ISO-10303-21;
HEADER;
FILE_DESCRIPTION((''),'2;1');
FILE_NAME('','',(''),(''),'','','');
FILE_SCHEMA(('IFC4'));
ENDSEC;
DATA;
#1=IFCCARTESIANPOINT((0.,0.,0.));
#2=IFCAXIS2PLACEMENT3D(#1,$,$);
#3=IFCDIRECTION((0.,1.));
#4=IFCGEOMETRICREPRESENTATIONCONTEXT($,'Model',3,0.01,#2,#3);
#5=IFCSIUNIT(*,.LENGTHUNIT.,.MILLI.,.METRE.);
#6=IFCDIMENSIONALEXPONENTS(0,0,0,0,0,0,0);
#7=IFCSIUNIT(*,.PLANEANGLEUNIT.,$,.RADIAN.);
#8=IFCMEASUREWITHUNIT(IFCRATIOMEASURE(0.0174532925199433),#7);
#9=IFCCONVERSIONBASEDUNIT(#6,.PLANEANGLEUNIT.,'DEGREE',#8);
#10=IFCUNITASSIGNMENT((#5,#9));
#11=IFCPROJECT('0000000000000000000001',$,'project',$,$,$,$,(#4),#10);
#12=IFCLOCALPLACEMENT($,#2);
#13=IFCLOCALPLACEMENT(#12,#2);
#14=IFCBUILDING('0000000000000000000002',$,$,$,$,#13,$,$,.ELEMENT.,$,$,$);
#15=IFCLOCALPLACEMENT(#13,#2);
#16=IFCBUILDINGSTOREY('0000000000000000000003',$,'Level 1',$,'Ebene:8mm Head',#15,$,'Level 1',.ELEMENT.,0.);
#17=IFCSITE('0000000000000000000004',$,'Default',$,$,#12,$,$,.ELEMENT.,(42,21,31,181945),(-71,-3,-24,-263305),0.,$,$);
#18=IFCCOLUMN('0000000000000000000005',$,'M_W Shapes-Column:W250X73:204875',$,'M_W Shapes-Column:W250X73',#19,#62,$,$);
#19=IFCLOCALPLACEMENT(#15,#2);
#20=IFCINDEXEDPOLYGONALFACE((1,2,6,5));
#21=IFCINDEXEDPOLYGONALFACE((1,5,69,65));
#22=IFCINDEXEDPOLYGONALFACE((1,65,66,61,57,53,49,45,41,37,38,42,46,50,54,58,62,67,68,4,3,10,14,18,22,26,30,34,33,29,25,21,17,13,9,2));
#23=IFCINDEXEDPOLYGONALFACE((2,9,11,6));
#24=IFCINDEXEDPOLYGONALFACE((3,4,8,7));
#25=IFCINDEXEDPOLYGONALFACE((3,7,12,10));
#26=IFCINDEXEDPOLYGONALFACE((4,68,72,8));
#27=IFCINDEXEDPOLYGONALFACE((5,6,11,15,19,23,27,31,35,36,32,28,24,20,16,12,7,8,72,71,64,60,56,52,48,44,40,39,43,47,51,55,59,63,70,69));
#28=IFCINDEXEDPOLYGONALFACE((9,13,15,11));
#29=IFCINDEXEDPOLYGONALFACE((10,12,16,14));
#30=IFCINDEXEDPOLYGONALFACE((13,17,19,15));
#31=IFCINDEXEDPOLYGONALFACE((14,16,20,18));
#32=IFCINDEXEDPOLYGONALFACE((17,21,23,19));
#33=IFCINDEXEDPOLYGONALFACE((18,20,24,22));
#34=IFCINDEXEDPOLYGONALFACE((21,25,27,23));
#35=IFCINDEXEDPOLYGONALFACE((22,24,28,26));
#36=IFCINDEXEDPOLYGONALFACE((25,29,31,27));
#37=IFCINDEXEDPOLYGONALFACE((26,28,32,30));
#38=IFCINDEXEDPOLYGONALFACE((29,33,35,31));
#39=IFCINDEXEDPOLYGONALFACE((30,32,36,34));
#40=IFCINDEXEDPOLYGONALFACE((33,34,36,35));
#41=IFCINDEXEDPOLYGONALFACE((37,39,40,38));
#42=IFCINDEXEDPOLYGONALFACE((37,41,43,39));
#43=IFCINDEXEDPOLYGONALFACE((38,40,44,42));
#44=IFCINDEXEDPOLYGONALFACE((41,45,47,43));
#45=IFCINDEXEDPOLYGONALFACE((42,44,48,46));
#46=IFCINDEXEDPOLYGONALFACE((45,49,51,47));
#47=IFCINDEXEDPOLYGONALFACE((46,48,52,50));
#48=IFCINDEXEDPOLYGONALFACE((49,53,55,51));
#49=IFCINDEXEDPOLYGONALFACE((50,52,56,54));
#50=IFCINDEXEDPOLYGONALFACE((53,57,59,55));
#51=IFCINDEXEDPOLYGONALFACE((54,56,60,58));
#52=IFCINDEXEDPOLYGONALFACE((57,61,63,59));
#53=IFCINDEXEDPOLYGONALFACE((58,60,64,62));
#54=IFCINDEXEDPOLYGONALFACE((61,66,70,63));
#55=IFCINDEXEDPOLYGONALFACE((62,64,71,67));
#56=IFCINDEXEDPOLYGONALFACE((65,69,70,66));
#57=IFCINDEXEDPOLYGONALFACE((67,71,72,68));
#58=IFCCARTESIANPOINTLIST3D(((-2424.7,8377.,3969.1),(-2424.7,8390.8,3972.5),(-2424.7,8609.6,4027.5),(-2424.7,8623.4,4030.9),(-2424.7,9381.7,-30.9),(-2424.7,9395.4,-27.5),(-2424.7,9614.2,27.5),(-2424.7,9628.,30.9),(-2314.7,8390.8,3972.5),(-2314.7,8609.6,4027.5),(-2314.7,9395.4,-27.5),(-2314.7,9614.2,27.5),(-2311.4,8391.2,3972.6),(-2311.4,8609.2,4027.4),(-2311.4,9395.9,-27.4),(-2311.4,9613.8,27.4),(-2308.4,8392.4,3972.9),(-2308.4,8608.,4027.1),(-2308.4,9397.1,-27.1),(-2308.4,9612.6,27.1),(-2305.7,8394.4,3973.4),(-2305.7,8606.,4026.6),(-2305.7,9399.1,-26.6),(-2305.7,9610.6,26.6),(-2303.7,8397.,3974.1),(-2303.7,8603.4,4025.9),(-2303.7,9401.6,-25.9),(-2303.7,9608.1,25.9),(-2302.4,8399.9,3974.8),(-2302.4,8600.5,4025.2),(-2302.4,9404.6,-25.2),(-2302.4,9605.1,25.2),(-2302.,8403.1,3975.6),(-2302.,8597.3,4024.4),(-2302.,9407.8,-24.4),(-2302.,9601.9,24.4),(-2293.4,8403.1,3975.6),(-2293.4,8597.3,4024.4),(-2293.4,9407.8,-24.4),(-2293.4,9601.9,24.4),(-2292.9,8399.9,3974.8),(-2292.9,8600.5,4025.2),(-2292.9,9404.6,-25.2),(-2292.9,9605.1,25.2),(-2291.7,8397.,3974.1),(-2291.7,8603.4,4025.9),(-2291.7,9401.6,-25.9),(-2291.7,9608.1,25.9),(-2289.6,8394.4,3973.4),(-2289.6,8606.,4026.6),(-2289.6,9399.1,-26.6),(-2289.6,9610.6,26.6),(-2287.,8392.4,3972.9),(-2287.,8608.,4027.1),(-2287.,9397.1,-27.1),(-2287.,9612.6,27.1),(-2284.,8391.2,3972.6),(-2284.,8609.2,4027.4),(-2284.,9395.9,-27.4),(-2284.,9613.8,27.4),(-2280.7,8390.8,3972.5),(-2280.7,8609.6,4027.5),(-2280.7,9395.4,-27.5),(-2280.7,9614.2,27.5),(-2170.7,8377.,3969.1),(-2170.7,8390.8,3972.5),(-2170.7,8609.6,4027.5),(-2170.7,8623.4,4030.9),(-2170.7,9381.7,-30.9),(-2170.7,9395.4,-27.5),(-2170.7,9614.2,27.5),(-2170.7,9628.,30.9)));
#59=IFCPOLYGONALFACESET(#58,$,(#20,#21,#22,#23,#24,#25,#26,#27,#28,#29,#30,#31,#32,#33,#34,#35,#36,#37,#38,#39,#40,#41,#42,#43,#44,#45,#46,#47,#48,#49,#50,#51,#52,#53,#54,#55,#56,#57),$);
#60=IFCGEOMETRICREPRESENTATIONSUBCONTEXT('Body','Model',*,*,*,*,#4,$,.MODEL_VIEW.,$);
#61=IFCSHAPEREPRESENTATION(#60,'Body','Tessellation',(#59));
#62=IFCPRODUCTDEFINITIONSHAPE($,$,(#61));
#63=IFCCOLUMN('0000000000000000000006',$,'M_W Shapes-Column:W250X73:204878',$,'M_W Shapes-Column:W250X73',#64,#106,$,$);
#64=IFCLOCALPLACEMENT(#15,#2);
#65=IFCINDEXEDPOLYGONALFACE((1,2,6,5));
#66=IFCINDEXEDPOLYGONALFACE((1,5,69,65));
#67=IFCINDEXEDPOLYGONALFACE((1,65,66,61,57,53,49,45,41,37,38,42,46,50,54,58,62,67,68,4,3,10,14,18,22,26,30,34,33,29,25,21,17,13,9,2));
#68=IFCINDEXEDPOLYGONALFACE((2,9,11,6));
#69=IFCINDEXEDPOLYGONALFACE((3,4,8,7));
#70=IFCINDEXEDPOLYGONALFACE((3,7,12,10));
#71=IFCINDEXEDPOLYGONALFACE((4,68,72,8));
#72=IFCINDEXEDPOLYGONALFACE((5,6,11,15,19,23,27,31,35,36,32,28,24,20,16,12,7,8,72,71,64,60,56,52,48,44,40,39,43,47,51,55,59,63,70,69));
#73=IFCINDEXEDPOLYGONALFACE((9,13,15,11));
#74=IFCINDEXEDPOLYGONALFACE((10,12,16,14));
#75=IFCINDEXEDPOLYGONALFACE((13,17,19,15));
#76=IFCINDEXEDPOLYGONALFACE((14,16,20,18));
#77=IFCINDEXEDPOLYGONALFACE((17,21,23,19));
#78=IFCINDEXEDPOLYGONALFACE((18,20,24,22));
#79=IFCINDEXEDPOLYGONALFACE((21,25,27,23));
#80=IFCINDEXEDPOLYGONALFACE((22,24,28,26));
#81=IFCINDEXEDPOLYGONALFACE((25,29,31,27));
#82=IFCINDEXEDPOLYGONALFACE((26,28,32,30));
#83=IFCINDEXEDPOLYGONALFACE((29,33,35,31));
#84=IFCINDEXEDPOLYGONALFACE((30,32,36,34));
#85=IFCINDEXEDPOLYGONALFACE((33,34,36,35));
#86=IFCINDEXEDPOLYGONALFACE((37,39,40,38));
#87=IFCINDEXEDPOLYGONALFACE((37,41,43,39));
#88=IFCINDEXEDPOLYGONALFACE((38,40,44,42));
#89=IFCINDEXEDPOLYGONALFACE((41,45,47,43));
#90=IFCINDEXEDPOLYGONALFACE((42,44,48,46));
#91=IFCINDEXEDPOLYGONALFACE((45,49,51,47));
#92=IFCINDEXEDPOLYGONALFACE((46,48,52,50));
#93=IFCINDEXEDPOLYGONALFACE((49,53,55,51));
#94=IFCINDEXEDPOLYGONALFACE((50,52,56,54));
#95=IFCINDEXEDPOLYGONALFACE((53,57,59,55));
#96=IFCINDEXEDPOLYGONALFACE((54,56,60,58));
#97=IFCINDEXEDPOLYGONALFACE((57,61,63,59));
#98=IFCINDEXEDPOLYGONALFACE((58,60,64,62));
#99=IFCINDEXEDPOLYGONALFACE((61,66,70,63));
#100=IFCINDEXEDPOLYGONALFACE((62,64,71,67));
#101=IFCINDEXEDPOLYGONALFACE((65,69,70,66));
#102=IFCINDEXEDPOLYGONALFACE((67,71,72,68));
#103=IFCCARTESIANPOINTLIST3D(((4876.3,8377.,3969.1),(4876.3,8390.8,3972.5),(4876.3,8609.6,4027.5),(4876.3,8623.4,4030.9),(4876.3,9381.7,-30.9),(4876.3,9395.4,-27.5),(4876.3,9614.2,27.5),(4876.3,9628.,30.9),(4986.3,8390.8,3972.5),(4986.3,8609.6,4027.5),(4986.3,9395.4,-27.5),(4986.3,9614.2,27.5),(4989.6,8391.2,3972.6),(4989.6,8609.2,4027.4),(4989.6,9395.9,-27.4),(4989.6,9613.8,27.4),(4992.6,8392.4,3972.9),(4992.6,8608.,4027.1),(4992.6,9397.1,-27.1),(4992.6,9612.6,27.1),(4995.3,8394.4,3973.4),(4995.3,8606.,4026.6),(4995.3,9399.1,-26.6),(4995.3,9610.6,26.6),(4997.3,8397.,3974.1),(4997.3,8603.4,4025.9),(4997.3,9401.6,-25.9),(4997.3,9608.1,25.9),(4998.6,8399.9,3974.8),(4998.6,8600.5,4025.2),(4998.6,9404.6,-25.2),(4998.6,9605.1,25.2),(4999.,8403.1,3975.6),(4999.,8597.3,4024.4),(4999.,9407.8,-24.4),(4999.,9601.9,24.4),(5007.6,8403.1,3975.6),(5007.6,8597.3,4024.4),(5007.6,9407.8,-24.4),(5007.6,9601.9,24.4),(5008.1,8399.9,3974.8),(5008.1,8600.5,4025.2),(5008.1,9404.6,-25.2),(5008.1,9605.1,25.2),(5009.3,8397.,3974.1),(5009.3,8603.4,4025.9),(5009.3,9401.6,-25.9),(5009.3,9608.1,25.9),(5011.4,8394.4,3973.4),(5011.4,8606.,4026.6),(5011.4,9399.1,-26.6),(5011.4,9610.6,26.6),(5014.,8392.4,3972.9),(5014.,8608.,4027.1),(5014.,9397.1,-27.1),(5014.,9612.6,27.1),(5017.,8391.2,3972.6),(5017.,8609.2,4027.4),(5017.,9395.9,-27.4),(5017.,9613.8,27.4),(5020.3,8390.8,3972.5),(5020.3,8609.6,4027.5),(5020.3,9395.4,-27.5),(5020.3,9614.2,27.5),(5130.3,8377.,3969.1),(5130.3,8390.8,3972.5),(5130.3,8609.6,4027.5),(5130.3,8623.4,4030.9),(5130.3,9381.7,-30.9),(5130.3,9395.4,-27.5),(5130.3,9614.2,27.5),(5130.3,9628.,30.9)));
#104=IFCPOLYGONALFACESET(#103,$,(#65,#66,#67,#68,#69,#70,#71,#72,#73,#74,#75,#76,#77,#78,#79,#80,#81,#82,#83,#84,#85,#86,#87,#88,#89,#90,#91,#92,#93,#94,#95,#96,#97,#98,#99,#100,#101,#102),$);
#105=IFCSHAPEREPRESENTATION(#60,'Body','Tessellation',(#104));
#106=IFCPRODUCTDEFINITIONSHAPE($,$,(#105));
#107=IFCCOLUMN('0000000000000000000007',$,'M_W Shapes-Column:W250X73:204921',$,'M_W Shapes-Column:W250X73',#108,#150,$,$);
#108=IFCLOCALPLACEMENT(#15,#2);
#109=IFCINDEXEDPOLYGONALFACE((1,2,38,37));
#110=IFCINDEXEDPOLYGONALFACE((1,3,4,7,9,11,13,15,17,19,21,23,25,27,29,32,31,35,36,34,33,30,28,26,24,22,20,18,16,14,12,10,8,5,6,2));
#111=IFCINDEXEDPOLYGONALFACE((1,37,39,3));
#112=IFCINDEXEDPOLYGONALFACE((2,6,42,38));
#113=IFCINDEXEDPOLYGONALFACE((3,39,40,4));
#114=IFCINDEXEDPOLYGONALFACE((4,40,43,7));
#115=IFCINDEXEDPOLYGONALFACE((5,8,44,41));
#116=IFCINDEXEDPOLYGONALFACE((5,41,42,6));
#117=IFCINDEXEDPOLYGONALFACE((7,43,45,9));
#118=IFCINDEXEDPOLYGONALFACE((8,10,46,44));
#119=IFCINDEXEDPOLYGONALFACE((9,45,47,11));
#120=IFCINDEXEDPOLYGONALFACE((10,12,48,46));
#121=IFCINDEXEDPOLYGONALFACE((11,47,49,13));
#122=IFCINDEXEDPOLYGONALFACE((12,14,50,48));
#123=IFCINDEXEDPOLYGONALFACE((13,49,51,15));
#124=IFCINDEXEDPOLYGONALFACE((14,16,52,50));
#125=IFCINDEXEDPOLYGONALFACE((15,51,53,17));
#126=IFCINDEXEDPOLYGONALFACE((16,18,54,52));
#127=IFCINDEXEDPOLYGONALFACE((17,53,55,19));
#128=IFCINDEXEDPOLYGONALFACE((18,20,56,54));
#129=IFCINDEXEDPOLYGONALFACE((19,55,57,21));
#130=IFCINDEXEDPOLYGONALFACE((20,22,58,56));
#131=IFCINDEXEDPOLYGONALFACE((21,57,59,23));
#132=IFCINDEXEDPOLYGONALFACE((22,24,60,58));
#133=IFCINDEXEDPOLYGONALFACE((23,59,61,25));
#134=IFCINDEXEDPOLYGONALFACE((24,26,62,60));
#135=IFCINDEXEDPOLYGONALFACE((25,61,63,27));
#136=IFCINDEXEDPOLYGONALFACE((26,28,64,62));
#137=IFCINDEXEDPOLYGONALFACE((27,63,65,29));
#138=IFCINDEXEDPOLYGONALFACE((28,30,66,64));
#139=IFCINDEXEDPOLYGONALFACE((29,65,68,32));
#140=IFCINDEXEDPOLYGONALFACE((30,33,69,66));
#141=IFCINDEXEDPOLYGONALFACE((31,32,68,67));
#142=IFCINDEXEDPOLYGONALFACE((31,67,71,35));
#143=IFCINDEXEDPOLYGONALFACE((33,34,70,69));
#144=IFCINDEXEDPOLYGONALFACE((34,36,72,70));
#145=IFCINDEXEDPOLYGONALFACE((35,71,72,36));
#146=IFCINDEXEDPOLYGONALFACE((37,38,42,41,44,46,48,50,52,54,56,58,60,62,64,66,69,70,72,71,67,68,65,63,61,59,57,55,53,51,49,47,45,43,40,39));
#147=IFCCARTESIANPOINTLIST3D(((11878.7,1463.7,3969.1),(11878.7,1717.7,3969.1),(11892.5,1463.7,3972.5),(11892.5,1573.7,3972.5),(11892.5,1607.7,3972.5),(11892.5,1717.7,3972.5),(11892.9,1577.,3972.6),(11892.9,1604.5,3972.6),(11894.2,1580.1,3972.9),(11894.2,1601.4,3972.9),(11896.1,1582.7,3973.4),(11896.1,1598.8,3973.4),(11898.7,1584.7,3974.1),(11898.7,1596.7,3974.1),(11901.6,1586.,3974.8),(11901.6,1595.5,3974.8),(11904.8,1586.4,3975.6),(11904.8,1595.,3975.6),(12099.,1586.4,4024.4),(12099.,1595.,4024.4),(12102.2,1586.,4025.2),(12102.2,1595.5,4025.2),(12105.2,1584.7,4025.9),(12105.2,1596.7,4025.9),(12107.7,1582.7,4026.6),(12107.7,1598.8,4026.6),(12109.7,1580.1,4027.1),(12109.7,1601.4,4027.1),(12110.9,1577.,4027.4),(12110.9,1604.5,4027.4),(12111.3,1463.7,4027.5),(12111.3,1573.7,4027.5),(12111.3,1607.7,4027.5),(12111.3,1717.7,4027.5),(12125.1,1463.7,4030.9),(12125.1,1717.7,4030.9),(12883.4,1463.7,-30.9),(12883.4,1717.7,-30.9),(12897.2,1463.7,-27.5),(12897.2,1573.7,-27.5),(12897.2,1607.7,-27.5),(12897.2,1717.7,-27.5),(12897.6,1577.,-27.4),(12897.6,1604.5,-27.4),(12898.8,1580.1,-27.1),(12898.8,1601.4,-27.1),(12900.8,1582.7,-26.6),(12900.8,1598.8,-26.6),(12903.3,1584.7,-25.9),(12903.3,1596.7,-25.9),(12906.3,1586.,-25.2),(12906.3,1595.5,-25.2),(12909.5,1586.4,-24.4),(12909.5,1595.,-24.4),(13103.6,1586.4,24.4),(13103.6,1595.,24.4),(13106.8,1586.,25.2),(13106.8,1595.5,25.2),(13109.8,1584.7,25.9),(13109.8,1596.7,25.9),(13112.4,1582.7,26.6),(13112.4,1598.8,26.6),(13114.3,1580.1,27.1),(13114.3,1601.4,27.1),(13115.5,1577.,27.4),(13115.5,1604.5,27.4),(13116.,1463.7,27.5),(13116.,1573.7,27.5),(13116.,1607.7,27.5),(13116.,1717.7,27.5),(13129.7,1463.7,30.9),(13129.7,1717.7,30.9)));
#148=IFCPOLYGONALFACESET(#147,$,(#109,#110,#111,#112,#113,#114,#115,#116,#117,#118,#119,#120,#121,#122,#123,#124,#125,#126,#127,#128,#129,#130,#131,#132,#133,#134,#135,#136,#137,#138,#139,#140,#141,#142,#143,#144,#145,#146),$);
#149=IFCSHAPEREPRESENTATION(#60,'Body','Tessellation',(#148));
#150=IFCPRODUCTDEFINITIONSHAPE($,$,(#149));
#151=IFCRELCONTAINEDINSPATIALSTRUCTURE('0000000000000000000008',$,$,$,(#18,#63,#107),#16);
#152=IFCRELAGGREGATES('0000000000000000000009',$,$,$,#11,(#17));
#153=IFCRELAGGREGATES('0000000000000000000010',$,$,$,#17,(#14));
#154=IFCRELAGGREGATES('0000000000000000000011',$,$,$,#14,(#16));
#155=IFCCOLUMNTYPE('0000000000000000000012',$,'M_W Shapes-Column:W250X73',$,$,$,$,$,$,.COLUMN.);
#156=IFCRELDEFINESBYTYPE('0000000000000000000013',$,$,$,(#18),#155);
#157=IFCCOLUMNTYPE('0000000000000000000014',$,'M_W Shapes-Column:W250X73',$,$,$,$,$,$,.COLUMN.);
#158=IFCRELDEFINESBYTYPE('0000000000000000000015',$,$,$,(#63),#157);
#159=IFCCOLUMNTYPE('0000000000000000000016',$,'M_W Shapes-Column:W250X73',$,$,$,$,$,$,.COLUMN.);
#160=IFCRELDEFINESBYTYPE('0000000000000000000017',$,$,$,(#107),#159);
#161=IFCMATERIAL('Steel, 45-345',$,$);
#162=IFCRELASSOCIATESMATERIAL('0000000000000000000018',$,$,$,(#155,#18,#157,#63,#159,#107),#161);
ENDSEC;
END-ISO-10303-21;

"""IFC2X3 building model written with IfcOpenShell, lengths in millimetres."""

from ifc_helpers import new_model, entity, si_unit, converted_unit, direction, frame, frame_2d, origin, place, context, subcontext, project, spatial, polyline, circle_curve, parameter, trimmed, segment, composite_curve, i_section, outline, extrude, source, transform, mapped, material, type_object, type_shapes, element, save


model = new_model("IFC2X3")

# Units and contexts
model_context = context("Model", 3, precision=0.01, world=origin(), true_north=direction((0.0, 1.0)))
body_context = subcontext(model_context, "Body", "Model", "MODEL_VIEW")
ifc_project = project(units=[si_unit("LENGTHUNIT", "METRE", prefix="MILLI"), converted_unit("PLANEANGLEUNIT", "DEGREE", entity("IfcRatioMeasure", 0.0174532925199433), si_unit("PLANEANGLEUNIT", "RADIAN"), dimensions=[0, 0, 0, 0, 0, 0, 0])], contexts=[model_context])

# Site, building, storey
site_placement = place(None, origin())
site = spatial("IfcSite", under=ifc_project, at=site_placement, Name="Default", CompositionType="ELEMENT", RefLatitude=(42, 21, 31, 181945), RefLongitude=(-71, -3, -24, -263305), RefElevation=0.0)
building_placement = place(site_placement, origin())
building = spatial("IfcBuilding", under=site, at=building_placement, CompositionType="ELEMENT")
storey_placement = place(building_placement, origin())
storey = spatial("IfcBuildingStorey", under=building, at=storey_placement, Name="Level 1", ObjectType="Ebene:8mm Head", LongName="Level 1", CompositionType="ELEMENT", Elevation=0.0)

# Columns
ifc_material_1 = material(Name="Steel, 45-345")
column_type_1 = type_object("IfcColumnType", Name="M_W Shapes-Column:W250X73", PredefinedType="COLUMN", material=ifc_material_1)
shared_shape_1 = source(origin(), body_context, "Body", "SweptSolid", [
    extrude(outline(composite_curve([segment(polyline([(112.8, -127.0), (127.0, -127.0)]), True, "CONTINUOUS"), segment(polyline([(127.0, -127.0), (127.0, 127.0)]), True, "CONTINUOUS"), segment(polyline([(127.0, 127.0), (112.8, 127.0)]), True, "CONTINUOUS"), segment(polyline([(112.8, 127.0), (112.8, 17.0)]), True, "CONTINUOUS"), segment(trimmed(circle_curve(frame_2d((100.1, 17.0), x_axis=(1.0, 0.0)), 12.7), [parameter(270.0)], [parameter(0.0)], True, "PARAMETER"), False, "CONTINUOUS"), segment(polyline([(100.1, 4.3), (-100.1, 4.3)]), True, "CONTINUOUS"), segment(trimmed(circle_curve(frame_2d((-100.1, 17.0), x_axis=(0.0, -1.0)), 12.7), [parameter(270.0)], [parameter(0.0)], True, "PARAMETER"), False, "CONTINUOUS"), segment(polyline([(-112.8, 17.0), (-112.8, 127.0)]), True, "CONTINUOUS"), segment(polyline([(-112.8, 127.0), (-127.0, 127.0)]), True, "CONTINUOUS"), segment(polyline([(-127.0, 127.0), (-127.0, -127.0)]), True, "CONTINUOUS"), segment(polyline([(-127.0, -127.0), (-112.8, -127.0)]), True, "CONTINUOUS"), segment(polyline([(-112.8, -127.0), (-112.8, -17.0)]), True, "CONTINUOUS"), segment(trimmed(circle_curve(frame_2d((-100.1, -17.0), x_axis=(-1.0, 0.0)), 12.7), [parameter(270.0)], [parameter(0.0)], True, "PARAMETER"), False, "CONTINUOUS"), segment(polyline([(-100.1, -4.3), (100.1, -4.3)]), True, "CONTINUOUS"), segment(trimmed(circle_curve(frame_2d((100.1, -17.0), x_axis=(0.0, 1.0)), 12.7), [parameter(270.0)], [parameter(0.0)], True, "PARAMETER"), False, "CONTINUOUS"), segment(polyline([(112.8, -17.0), (112.8, -127.0)]), True, "CONTINUOUS")], self_intersect=False)), frame((-2297.7, 9504.8, 0.0), z_axis=(0.0, -0.243596, 0.969877), x_axis=(0.0, -0.969877, -0.243596)), (0.0, 0.0, 1.0), 4124.2),
])
type_shapes(column_type_1, [shared_shape_1])
column_1_placement = place(storey_placement, origin())
element("IfcColumn", 1, at=column_1_placement, inside=storey, type_object=column_type_1, material=ifc_material_1, Name="M_W Shapes-Column:W250X73:204875", ObjectType="M_W Shapes-Column:W250X73", context=body_context, shape_type="MappedRepresentation", body=[
    mapped(shared_shape_1, transform((0.0, 0.0, 0.0), scale=1.0)),
])
column_type_2 = type_object("IfcColumnType", Name="M_W Shapes-Column:W250X73", PredefinedType="COLUMN", material=ifc_material_1)
shared_shape_2 = source(origin(), body_context, "Body", "SweptSolid", [
    extrude(outline(composite_curve([segment(polyline([(112.8, -127.0), (127.0, -127.0)]), True, "CONTINUOUS"), segment(polyline([(127.0, -127.0), (127.0, 127.0)]), True, "CONTINUOUS"), segment(polyline([(127.0, 127.0), (112.8, 127.0)]), True, "CONTINUOUS"), segment(polyline([(112.8, 127.0), (112.8, 17.0)]), True, "CONTINUOUS"), segment(trimmed(circle_curve(frame_2d((100.1, 17.0), x_axis=(1.0, 0.0)), 12.7), [parameter(270.0)], [parameter(0.0)], True, "PARAMETER"), False, "CONTINUOUS"), segment(polyline([(100.1, 4.3), (-100.1, 4.3)]), True, "CONTINUOUS"), segment(trimmed(circle_curve(frame_2d((-100.1, 17.0), x_axis=(0.0, -1.0)), 12.7), [parameter(270.0)], [parameter(0.0)], True, "PARAMETER"), False, "CONTINUOUS"), segment(polyline([(-112.8, 17.0), (-112.8, 127.0)]), True, "CONTINUOUS"), segment(polyline([(-112.8, 127.0), (-127.0, 127.0)]), True, "CONTINUOUS"), segment(polyline([(-127.0, 127.0), (-127.0, -127.0)]), True, "CONTINUOUS"), segment(polyline([(-127.0, -127.0), (-112.8, -127.0)]), True, "CONTINUOUS"), segment(polyline([(-112.8, -127.0), (-112.8, -17.0)]), True, "CONTINUOUS"), segment(trimmed(circle_curve(frame_2d((-100.1, -17.0), x_axis=(-1.0, 0.0)), 12.7), [parameter(270.0)], [parameter(0.0)], True, "PARAMETER"), False, "CONTINUOUS"), segment(polyline([(-100.1, -4.3), (100.1, -4.3)]), True, "CONTINUOUS"), segment(trimmed(circle_curve(frame_2d((100.1, -17.0), x_axis=(0.0, 1.0)), 12.7), [parameter(270.0)], [parameter(0.0)], True, "PARAMETER"), False, "CONTINUOUS"), segment(polyline([(112.8, -17.0), (112.8, -127.0)]), True, "CONTINUOUS")], self_intersect=False)), frame((5003.3, 9504.8, 0.0), z_axis=(0.0, -0.243596, 0.969877), x_axis=(0.0, -0.969877, -0.243596)), (0.0, 0.0, 1.0), 4124.2),
])
type_shapes(column_type_2, [shared_shape_2])
column_2_placement = place(storey_placement, origin())
element("IfcColumn", 2, at=column_2_placement, inside=storey, type_object=column_type_2, material=ifc_material_1, Name="M_W Shapes-Column:W250X73:204878", ObjectType="M_W Shapes-Column:W250X73", context=body_context, shape_type="MappedRepresentation", body=[
    mapped(shared_shape_2, transform((0.0, 0.0, 0.0), scale=1.0)),
])
column_type_3 = type_object("IfcColumnType", Name="M_W Shapes-Column:W250X73", PredefinedType="COLUMN", material=ifc_material_1)
shared_shape_3 = source(origin(), body_context, "Body", "SweptSolid", [
    extrude(i_section(OverallWidth=254.0, OverallDepth=254.0, WebThickness=8.6, FlangeThickness=14.2, FilletRadius=12.7, at=frame_2d((0.0, 0.0), x_axis=(1.0, 0.0))), frame((13006.6, 1590.7, 0.0), z_axis=(-0.243596, 0.0, 0.969877), x_axis=(0.0, -1.0, 0.0)), (0.0, 0.0, 1.0), 4124.2),
])
type_shapes(column_type_3, [shared_shape_3])
column_3_placement = place(storey_placement, origin())
element("IfcColumn", 3, at=column_3_placement, inside=storey, type_object=column_type_3, material=ifc_material_1, Name="M_W Shapes-Column:W250X73:204921", ObjectType="M_W Shapes-Column:W250X73", context=body_context, shape_type="MappedRepresentation", body=[
    mapped(shared_shape_3, transform((0.0, 0.0, 0.0), scale=1.0)),
])

save(model, "model.ifc")
